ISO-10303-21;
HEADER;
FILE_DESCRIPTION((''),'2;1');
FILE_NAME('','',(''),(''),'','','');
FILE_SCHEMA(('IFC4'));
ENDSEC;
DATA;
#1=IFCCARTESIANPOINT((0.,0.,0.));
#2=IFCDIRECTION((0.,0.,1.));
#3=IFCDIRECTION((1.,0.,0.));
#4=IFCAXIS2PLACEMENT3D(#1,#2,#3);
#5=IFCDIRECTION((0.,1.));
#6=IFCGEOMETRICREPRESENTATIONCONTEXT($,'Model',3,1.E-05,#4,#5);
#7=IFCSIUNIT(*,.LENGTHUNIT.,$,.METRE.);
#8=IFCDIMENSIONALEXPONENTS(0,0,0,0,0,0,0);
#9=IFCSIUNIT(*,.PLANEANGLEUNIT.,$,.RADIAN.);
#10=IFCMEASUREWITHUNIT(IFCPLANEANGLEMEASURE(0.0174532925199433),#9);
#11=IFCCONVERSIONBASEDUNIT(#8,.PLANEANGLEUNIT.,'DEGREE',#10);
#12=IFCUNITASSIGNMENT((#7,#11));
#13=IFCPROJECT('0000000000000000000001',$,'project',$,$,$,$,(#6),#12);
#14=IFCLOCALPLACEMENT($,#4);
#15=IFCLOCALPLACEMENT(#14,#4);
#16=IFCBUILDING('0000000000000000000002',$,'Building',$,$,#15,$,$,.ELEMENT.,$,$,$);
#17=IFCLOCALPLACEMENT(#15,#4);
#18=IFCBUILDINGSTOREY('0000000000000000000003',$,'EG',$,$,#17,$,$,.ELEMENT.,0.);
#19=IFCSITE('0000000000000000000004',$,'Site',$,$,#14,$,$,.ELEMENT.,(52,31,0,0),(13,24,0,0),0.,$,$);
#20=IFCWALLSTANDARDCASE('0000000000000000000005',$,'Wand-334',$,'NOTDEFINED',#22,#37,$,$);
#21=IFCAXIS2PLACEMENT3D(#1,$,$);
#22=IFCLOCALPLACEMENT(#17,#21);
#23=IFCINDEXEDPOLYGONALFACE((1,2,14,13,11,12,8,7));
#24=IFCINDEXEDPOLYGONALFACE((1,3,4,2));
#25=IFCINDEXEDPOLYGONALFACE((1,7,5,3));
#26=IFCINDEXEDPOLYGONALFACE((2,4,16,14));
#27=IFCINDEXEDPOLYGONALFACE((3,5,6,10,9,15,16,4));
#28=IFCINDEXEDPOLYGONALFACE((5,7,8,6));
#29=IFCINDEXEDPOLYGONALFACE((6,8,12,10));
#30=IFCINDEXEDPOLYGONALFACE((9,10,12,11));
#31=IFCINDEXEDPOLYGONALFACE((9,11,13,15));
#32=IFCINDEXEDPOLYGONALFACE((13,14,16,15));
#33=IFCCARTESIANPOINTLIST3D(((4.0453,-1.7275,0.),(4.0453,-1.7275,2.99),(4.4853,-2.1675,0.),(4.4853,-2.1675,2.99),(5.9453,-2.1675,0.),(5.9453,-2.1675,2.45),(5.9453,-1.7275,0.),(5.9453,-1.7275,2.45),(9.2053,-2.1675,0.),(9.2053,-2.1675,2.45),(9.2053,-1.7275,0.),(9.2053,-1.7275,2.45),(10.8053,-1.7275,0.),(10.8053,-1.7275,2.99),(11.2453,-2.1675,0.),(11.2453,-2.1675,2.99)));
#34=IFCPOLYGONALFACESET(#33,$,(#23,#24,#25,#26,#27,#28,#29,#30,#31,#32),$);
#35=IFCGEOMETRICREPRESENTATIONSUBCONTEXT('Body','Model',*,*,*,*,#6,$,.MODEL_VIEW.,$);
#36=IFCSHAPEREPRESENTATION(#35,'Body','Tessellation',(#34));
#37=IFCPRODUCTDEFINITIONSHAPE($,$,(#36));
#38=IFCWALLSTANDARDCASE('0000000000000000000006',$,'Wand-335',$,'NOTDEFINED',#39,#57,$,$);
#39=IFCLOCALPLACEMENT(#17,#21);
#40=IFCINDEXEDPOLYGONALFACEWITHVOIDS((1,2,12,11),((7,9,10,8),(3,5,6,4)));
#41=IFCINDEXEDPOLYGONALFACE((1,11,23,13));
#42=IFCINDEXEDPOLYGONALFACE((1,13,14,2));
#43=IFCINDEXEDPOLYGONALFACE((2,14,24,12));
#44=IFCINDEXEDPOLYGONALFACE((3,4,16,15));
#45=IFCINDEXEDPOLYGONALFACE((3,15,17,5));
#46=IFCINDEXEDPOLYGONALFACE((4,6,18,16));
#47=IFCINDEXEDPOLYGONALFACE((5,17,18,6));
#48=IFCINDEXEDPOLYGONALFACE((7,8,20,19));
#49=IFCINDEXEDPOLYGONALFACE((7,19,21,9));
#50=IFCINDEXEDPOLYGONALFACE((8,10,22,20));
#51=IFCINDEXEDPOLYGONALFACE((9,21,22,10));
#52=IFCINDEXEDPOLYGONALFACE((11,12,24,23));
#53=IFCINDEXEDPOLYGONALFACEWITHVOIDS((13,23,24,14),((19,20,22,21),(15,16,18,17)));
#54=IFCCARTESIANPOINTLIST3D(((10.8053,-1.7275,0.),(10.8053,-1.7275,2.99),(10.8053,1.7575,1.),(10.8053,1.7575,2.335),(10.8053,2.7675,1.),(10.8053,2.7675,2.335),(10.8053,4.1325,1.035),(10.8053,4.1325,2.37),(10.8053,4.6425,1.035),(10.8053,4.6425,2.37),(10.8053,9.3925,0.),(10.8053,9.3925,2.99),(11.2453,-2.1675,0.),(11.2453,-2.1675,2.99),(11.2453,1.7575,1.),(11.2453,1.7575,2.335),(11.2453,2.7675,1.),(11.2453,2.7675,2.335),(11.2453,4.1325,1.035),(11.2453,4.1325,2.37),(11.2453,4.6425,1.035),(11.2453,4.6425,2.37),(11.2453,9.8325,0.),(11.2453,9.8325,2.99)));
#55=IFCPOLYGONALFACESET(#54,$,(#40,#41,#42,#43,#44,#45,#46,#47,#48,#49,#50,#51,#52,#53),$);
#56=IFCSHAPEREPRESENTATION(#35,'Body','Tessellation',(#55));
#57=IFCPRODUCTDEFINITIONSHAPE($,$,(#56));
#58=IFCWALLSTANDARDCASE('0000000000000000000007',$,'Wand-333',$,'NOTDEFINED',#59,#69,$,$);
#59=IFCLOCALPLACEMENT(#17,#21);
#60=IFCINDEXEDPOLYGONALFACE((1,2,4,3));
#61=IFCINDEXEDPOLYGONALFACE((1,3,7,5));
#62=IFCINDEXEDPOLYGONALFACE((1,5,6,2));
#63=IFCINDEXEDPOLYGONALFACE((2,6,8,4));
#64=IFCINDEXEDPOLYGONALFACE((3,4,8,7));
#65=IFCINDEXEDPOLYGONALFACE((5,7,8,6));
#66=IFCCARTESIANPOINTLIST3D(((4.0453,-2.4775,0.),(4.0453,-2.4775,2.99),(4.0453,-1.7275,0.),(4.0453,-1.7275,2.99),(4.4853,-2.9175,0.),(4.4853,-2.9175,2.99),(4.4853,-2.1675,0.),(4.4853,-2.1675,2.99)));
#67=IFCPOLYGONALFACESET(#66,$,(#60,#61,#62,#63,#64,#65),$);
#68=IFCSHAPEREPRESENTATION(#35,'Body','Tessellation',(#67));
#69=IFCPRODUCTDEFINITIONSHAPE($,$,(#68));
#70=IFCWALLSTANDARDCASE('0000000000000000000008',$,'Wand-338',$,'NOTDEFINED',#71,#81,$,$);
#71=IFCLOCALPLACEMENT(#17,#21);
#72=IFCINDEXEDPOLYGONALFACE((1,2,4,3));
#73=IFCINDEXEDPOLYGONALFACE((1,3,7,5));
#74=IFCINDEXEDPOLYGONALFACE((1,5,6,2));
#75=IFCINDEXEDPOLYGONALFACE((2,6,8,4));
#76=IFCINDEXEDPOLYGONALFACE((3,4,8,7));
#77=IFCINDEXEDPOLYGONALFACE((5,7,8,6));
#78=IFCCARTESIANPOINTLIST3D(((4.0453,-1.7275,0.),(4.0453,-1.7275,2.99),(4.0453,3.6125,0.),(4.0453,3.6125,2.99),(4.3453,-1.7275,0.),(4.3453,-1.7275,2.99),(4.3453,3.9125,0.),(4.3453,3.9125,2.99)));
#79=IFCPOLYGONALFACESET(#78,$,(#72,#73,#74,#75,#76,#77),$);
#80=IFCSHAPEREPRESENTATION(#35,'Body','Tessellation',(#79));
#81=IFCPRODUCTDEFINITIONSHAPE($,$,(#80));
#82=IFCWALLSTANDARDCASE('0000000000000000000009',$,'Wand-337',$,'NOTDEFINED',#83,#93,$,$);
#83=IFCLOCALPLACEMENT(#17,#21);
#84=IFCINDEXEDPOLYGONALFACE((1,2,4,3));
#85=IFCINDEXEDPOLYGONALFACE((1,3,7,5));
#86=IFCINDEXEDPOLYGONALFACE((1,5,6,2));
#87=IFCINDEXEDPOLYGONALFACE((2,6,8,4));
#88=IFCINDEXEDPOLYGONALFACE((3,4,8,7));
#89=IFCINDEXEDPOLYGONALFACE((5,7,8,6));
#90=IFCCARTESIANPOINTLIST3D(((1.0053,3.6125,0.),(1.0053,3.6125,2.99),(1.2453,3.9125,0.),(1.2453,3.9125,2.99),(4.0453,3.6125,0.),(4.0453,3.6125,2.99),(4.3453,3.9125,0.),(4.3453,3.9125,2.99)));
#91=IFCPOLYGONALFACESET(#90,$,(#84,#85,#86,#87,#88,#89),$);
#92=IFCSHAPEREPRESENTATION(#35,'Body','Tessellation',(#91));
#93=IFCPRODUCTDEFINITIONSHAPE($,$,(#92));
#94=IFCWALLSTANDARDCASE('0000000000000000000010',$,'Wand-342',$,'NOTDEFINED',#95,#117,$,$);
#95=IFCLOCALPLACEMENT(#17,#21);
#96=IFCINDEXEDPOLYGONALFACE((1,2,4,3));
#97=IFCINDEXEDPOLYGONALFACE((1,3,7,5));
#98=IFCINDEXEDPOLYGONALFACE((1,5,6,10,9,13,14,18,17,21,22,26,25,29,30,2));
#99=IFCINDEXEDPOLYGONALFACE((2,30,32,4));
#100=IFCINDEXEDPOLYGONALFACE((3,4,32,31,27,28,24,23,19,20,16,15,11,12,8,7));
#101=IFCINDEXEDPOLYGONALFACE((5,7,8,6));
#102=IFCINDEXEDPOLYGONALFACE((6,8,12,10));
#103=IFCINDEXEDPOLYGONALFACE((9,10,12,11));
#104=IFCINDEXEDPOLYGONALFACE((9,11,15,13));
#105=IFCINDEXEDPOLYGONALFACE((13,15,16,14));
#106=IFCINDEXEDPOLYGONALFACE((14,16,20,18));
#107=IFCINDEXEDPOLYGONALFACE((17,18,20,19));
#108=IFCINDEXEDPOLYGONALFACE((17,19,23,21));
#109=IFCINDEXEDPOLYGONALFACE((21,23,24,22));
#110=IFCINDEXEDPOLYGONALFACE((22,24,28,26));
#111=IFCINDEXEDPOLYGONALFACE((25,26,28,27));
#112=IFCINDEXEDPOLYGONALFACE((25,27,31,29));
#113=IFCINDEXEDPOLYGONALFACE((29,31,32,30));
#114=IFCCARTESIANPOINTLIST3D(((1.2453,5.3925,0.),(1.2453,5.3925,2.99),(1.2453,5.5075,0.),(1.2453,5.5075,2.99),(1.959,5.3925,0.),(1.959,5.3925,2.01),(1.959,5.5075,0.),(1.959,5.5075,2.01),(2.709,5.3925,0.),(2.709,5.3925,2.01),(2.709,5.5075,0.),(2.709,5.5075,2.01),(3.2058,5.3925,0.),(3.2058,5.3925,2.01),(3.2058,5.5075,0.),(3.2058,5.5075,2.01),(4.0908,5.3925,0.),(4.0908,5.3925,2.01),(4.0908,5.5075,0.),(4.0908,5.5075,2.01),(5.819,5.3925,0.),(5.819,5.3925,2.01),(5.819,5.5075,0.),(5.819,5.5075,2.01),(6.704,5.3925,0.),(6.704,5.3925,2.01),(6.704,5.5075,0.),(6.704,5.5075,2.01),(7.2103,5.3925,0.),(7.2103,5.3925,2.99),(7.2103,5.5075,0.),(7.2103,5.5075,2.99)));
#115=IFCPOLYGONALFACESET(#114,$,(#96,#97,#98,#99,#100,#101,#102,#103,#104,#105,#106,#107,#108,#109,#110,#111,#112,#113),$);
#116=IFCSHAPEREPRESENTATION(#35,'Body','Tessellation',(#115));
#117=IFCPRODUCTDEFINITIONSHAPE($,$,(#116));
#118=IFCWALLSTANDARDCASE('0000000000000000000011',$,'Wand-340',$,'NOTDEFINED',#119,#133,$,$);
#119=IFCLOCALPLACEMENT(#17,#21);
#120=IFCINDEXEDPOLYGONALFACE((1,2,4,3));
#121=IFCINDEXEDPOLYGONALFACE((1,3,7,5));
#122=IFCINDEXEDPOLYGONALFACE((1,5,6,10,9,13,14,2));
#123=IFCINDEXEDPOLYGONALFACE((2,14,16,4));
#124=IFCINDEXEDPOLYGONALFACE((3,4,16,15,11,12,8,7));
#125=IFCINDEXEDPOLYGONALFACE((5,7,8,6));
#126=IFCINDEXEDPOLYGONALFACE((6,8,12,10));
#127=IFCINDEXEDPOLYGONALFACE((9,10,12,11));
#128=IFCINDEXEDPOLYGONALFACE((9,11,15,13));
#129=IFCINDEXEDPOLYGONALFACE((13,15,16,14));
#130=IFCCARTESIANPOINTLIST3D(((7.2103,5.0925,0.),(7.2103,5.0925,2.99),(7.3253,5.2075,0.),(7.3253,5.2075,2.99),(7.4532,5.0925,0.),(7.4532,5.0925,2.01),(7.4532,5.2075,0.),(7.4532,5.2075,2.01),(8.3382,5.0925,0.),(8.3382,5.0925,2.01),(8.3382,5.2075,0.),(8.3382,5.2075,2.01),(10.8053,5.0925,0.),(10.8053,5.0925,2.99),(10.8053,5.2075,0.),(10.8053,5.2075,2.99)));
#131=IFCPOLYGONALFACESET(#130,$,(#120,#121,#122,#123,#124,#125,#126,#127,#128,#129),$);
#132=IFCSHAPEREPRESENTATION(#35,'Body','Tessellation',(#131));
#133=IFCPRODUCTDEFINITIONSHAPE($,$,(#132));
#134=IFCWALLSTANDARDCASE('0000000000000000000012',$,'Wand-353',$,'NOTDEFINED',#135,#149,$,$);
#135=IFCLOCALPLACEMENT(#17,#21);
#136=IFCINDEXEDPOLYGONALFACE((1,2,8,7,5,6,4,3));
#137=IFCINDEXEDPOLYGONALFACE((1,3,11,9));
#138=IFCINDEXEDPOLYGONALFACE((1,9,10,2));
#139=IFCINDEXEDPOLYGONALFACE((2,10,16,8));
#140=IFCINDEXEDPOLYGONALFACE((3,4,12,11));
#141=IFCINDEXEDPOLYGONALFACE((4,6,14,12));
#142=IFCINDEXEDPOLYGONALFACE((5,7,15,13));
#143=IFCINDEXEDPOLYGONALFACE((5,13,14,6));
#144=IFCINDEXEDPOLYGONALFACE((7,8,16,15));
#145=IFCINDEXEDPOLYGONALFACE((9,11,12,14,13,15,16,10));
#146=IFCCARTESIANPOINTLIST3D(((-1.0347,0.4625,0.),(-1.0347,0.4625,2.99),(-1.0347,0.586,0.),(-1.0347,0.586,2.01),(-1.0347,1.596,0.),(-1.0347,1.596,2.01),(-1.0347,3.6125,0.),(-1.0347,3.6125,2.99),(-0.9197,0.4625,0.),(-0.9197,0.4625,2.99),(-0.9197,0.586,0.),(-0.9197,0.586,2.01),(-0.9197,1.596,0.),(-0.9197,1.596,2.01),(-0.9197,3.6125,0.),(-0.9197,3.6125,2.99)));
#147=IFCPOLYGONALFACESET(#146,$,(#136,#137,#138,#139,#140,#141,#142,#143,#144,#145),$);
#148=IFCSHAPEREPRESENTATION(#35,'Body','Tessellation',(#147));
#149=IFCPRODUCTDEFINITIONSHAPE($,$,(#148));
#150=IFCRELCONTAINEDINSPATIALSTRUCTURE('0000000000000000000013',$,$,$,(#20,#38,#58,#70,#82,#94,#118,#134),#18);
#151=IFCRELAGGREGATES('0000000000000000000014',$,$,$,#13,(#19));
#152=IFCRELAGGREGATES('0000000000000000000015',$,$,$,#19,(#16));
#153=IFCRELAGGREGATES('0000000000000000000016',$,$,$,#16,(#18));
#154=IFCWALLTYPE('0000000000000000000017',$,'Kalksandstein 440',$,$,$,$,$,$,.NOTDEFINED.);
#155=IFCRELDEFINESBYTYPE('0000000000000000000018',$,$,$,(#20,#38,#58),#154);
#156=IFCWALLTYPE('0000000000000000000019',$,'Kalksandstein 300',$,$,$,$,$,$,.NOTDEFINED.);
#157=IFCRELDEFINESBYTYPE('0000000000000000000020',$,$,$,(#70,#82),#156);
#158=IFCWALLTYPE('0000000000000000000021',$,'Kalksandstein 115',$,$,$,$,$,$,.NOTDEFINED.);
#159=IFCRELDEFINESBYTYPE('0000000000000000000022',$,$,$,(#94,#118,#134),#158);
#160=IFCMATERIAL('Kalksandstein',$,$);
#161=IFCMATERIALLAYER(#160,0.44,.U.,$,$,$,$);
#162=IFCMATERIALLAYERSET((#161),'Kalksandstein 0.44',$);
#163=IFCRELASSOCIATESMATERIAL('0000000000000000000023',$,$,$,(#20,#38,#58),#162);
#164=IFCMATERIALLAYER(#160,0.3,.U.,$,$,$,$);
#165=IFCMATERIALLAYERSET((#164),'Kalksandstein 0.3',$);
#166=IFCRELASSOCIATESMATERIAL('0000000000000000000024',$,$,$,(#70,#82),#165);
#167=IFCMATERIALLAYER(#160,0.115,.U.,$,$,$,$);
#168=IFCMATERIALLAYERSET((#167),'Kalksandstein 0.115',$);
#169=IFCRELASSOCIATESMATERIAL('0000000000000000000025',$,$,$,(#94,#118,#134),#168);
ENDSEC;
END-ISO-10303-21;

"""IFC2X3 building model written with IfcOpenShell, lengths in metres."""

from ifc_helpers import new_model, entity, si_unit, converted_unit, direction, frame, origin_with_axes, origin_2d_with_axis, place, context, subcontext, project, spatial, polyline, rectangle, outline, extrude, material, layer, layer_set, layer_usage, type_object, element, save


model = new_model("IFC2X3")

# Units and contexts
model_context = context("Model", 3, precision=1e-05, world=origin_with_axes(), true_north=direction((0.0, 1.0)))
body_context = subcontext(model_context, "Body", "Model", "MODEL_VIEW")
ifc_project = project(units=[si_unit("LENGTHUNIT", "METRE"), converted_unit("PLANEANGLEUNIT", "DEGREE", entity("IfcPlaneAngleMeasure", 0.0174532925199433), si_unit("PLANEANGLEUNIT", "RADIAN"), dimensions=[0, 0, 0, 0, 0, 0, 0])], contexts=[model_context])

# Site, building, storey
site_placement = place(None, origin_with_axes())
site = spatial("IfcSite", under=ifc_project, at=site_placement, Name="Site", CompositionType="ELEMENT", RefLatitude=(52, 31, 0, 0), RefLongitude=(13, 24, 0, 0), RefElevation=0.0)
building_placement = place(site_placement, origin_with_axes())
building = spatial("IfcBuilding", under=site, at=building_placement, Name="Building", CompositionType="ELEMENT")
storey_placement = place(building_placement, origin_with_axes())
storey = spatial("IfcBuildingStorey", under=building, at=storey_placement, Name="EG", CompositionType="ELEMENT", Elevation=0.0)

# Shared definitions
ifc_material = material(Name="Kalksandstein")
ifc_layer_1 = layer(ifc_material, 0.44, ventilated="UNKNOWN")
ifc_layer_set_1 = layer_set([ifc_layer_1], Name="Kalksandstein 0.44")
wall_type_1 = type_object("IfcWallType", Name="Kalksandstein 440", PredefinedType="NOTDEFINED")

# Wall, opening
ifc_layer_usage_1 = layer_usage(ifc_layer_set_1, "AXIS2", "NEGATIVE", 0.44)
wall_1_placement = place(storey_placement, frame((4.4853, -2.1675, 0.0), z_axis=(0.0, 0.0, 1.0), x_axis=(1.0, 0.0, 0.0)))
wall_1 = element("IfcWallStandardCase", 1, at=wall_1_placement, inside=storey, type_object=wall_type_1, material=ifc_layer_usage_1, Name="Wand-334", ObjectType="NOTDEFINED", context=body_context, shape_type="SweptSolid", body=[
    extrude(outline(polyline([(0.0, 0.0), (6.76, 0.0), (6.32, 0.44), (-0.44, 0.44), (0.0, 0.0)])), origin_with_axes(), (0.0, 0.0, 1.0), 2.99),
])
opening_1_placement = place(wall_1_placement, frame((3.09, 0.0, 0.0), z_axis=(0.0, 0.0, 1.0), x_axis=(1.0, 0.0, 0.0)))
element("IfcOpeningElement", 2, at=opening_1_placement, cuts=wall_1, context=body_context, shape_type="SweptSolid", body=[
    extrude(rectangle(XDim=3.26, YDim=2.45, at=origin_2d_with_axis()), frame((0.0, 0.44, 1.225), z_axis=(0.0, -1.0, 0.0), x_axis=(-1.0, 0.0, 0.0)), (0.0, 0.0, 1.0), 1.32),
])

# Wall, openings
ifc_layer_usage_2 = layer_usage(ifc_layer_set_1, "AXIS2", "NEGATIVE", 0.44)
wall_2_placement = place(storey_placement, frame((11.2453, -2.1675, 0.0), z_axis=(0.0, 0.0, 1.0), x_axis=(0.0, 1.0, 0.0)))
wall_2 = element("IfcWallStandardCase", 3, at=wall_2_placement, inside=storey, type_object=wall_type_1, material=ifc_layer_usage_2, Name="Wand-335", ObjectType="NOTDEFINED", context=body_context, shape_type="SweptSolid", body=[
    extrude(outline(polyline([(0.0, 0.0), (12.0, 0.0), (11.56, 0.44), (0.44, 0.44), (0.0, 0.0)])), origin_with_axes(), (0.0, 0.0, 1.0), 2.99),
])
opening_2_placement = place(wall_2_placement, frame((4.43, 0.0, 1.0), z_axis=(0.0, 0.0, 1.0), x_axis=(1.0, 0.0, 0.0)))
element("IfcOpeningElement", 4, at=opening_2_placement, cuts=wall_2, context=body_context, shape_type="SweptSolid", body=[
    extrude(rectangle(XDim=1.01, YDim=1.335, at=origin_2d_with_axis()), frame((0.0, 0.44, 0.6675), z_axis=(0.0, -1.0, 0.0), x_axis=(-1.0, 0.0, 0.0)), (0.0, 0.0, 1.0), 1.32),
])
opening_3_placement = place(wall_2_placement, frame((6.555, 0.0, 1.035), z_axis=(0.0, 0.0, 1.0), x_axis=(1.0, 0.0, 0.0)))
element("IfcOpeningElement", 5, at=opening_3_placement, cuts=wall_2, context=body_context, shape_type="SweptSolid", body=[
    extrude(rectangle(XDim=0.51, YDim=1.335, at=origin_2d_with_axis()), frame((0.0, 0.44, 0.6675), z_axis=(0.0, -1.0, 0.0), x_axis=(-1.0, 0.0, 0.0)), (0.0, 0.0, 1.0), 1.32),
])

# Walls
ifc_layer_usage_3 = layer_usage(ifc_layer_set_1, "AXIS2", "NEGATIVE", 0.44)
wall_3_placement = place(storey_placement, frame((4.4853, -2.9175, 0.0), z_axis=(0.0, 0.0, 1.0), x_axis=(0.0, 1.0, 0.0)))
element("IfcWallStandardCase", 6, at=wall_3_placement, inside=storey, type_object=wall_type_1, material=ifc_layer_usage_3, Name="Wand-333", ObjectType="NOTDEFINED", context=body_context, shape_type="SweptSolid", body=[
    extrude(outline(polyline([(0.0, 0.0), (0.75, 0.0), (1.19, 0.44), (0.44, 0.44), (0.0, 0.0)])), origin_with_axes(), (0.0, 0.0, 1.0), 2.99),
])
ifc_layer_2 = layer(ifc_material, 0.3, ventilated="UNKNOWN")
ifc_layer_set_2 = layer_set([ifc_layer_2], Name="Kalksandstein 0.3")
ifc_layer_usage_4 = layer_usage(ifc_layer_set_2, "AXIS2", "NEGATIVE", 0.3)
wall_type_2 = type_object("IfcWallType", Name="Kalksandstein 300", PredefinedType="NOTDEFINED")
wall_4_placement = place(storey_placement, frame((4.0453, 3.6125, 0.0), z_axis=(0.0, 0.0, 1.0), x_axis=(0.0, -1.0, 0.0)))
element("IfcWallStandardCase", 7, at=wall_4_placement, inside=storey, type_object=wall_type_2, material=ifc_layer_usage_4, Name="Wand-338", ObjectType="NOTDEFINED", context=body_context, shape_type="SweptSolid", body=[
    extrude(outline(polyline([(0.0, 0.0), (5.34, 0.0), (5.34, 0.3), (-0.3, 0.3), (0.0, 0.0)])), origin_with_axes(), (0.0, 0.0, 1.0), 2.99),
])
ifc_layer_usage_5 = layer_usage(ifc_layer_set_2, "AXIS2", "NEGATIVE", 0.3)
wall_5_placement = place(storey_placement, frame((1.2453, 3.6125, 0.0), z_axis=(0.0, 0.0, 1.0), x_axis=(1.0, 0.0, 0.0)))
element("IfcWallStandardCase", 8, at=wall_5_placement, inside=storey, type_object=wall_type_2, material=ifc_layer_usage_5, Name="Wand-337", ObjectType="NOTDEFINED", context=body_context, shape_type="SweptSolid", body=[
    extrude(outline(polyline([(-0.24, 0.0), (2.8, 0.0), (3.1, 0.3), (0.0, 0.3), (-0.24, 0.0)])), origin_with_axes(), (0.0, 0.0, 1.0), 2.99),
])
ifc_layer_3 = layer(ifc_material, 0.115, ventilated="UNKNOWN")
ifc_layer_set_3 = layer_set([ifc_layer_3], Name="Kalksandstein 0.115")
wall_type_3 = type_object("IfcWallType", Name="Kalksandstein 115", PredefinedType="NOTDEFINED")

# Wall, openings
ifc_layer_usage_6 = layer_usage(ifc_layer_set_3, "AXIS2", "POSITIVE", -0.115)
wall_6_placement = place(storey_placement, frame((1.2453, 5.5075, 0.0), z_axis=(0.0, 0.0, 1.0), x_axis=(1.0, 0.0, 0.0)))
wall_6 = element("IfcWallStandardCase", 9, at=wall_6_placement, inside=storey, type_object=wall_type_3, material=ifc_layer_usage_6, Name="Wand-342", ObjectType="NOTDEFINED", context=body_context, shape_type="SweptSolid", body=[
    extrude(outline(polyline([(0.0, -0.115), (5.965, -0.115), (5.965, 0.0), (0.0, 0.0), (0.0, -0.115)])), origin_with_axes(), (0.0, 0.0, 1.0), 2.99),
])
opening_4_placement = place(wall_6_placement, frame((2.403, 0.0, 0.0), z_axis=(0.0, 0.0, 1.0), x_axis=(1.0, 0.0, 0.0)))
element("IfcOpeningElement", 10, at=opening_4_placement, cuts=wall_6, context=body_context, shape_type="SweptSolid", body=[
    extrude(rectangle(XDim=0.885, YDim=2.01, at=origin_2d_with_axis()), frame((0.0, 0.115, 1.005), z_axis=(0.0, -1.0, 0.0), x_axis=(-1.0, 0.0, 0.0)), (0.0, 0.0, 1.0), 0.345),
])
opening_5_placement = place(wall_6_placement, frame((1.0887, 0.0, 0.0), z_axis=(0.0, 0.0, 1.0), x_axis=(1.0, 0.0, 0.0)))
element("IfcOpeningElement", 11, at=opening_5_placement, cuts=wall_6, context=body_context, shape_type="SweptSolid", body=[
    extrude(rectangle(XDim=0.75, YDim=2.01, at=origin_2d_with_axis()), frame((0.0, 0.115, 1.005), z_axis=(0.0, -1.0, 0.0), x_axis=(-1.0, 0.0, 0.0)), (0.0, 0.0, 1.0), 0.345),
])
opening_6_placement = place(wall_6_placement, frame((5.0163, 0.0, 0.0), z_axis=(0.0, 0.0, 1.0), x_axis=(1.0, 0.0, 0.0)))
element("IfcOpeningElement", 12, at=opening_6_placement, cuts=wall_6, context=body_context, shape_type="SweptSolid", body=[
    extrude(rectangle(XDim=0.885, YDim=2.01, at=origin_2d_with_axis()), frame((0.0, -0.115, 1.005), z_axis=(0.0, 1.0, 0.0), x_axis=(1.0, 0.0, 0.0)), (0.0, 0.0, 1.0), 0.345),
])

# Walls, openings
ifc_layer_usage_7 = layer_usage(ifc_layer_set_3, "AXIS2", "POSITIVE", -0.115)
wall_7_placement = place(storey_placement, frame((7.3253, 5.2075, 0.0), z_axis=(0.0, 0.0, 1.0), x_axis=(1.0, 0.0, 0.0)))
wall_7 = element("IfcWallStandardCase", 13, at=wall_7_placement, inside=storey, type_object=wall_type_3, material=ifc_layer_usage_7, Name="Wand-340", ObjectType="NOTDEFINED", context=body_context, shape_type="SweptSolid", body=[
    extrude(outline(polyline([(-0.115, -0.115), (3.48, -0.115), (3.48, 0.0), (0.0, 0.0), (-0.115, -0.115)])), origin_with_axes(), (0.0, 0.0, 1.0), 2.99),
])
opening_7_placement = place(wall_7_placement, frame((0.5705, 0.0, 0.0), z_axis=(0.0, 0.0, 1.0), x_axis=(1.0, 0.0, 0.0)))
element("IfcOpeningElement", 14, at=opening_7_placement, cuts=wall_7, context=body_context, shape_type="SweptSolid", body=[
    extrude(rectangle(XDim=0.885, YDim=2.01, at=origin_2d_with_axis()), frame((0.0, -0.115, 1.005), z_axis=(0.0, -1.0, 0.0), x_axis=(-1.0, 0.0, 0.0)), (0.0, 0.0, -1.0), 0.345),
])
ifc_layer_usage_8 = layer_usage(ifc_layer_set_3, "AXIS2", "POSITIVE", -0.115)
wall_8_placement = place(storey_placement, frame((-1.0347, 0.4625, 0.0), z_axis=(0.0, 0.0, 1.0), x_axis=(0.0, 1.0, 0.0)))
wall_8 = element("IfcWallStandardCase", 15, at=wall_8_placement, inside=storey, type_object=wall_type_3, material=ifc_layer_usage_8, Name="Wand-353", ObjectType="NOTDEFINED", context=body_context, shape_type="SweptSolid", body=[
    extrude(outline(polyline([(0.0, -0.115), (3.15, -0.115), (3.15, 0.0), (0.0, 0.0), (0.0, -0.115)])), origin_with_axes(), (0.0, 0.0, 1.0), 2.99),
])
opening_8_placement = place(wall_8_placement, frame((0.6285, 0.0, 0.0), z_axis=(0.0, 0.0, 1.0), x_axis=(1.0, 0.0, 0.0)))
element("IfcOpeningElement", 16, at=opening_8_placement, cuts=wall_8, context=body_context, shape_type="SweptSolid", body=[
    extrude(rectangle(XDim=1.01, YDim=2.01, at=origin_2d_with_axis()), frame((0.0, -0.115, 1.005), z_axis=(0.0, -1.0, 0.0), x_axis=(-1.0, 0.0, 0.0)), (0.0, 0.0, -1.0), 0.345),
])

save(model, "model.ifc")
